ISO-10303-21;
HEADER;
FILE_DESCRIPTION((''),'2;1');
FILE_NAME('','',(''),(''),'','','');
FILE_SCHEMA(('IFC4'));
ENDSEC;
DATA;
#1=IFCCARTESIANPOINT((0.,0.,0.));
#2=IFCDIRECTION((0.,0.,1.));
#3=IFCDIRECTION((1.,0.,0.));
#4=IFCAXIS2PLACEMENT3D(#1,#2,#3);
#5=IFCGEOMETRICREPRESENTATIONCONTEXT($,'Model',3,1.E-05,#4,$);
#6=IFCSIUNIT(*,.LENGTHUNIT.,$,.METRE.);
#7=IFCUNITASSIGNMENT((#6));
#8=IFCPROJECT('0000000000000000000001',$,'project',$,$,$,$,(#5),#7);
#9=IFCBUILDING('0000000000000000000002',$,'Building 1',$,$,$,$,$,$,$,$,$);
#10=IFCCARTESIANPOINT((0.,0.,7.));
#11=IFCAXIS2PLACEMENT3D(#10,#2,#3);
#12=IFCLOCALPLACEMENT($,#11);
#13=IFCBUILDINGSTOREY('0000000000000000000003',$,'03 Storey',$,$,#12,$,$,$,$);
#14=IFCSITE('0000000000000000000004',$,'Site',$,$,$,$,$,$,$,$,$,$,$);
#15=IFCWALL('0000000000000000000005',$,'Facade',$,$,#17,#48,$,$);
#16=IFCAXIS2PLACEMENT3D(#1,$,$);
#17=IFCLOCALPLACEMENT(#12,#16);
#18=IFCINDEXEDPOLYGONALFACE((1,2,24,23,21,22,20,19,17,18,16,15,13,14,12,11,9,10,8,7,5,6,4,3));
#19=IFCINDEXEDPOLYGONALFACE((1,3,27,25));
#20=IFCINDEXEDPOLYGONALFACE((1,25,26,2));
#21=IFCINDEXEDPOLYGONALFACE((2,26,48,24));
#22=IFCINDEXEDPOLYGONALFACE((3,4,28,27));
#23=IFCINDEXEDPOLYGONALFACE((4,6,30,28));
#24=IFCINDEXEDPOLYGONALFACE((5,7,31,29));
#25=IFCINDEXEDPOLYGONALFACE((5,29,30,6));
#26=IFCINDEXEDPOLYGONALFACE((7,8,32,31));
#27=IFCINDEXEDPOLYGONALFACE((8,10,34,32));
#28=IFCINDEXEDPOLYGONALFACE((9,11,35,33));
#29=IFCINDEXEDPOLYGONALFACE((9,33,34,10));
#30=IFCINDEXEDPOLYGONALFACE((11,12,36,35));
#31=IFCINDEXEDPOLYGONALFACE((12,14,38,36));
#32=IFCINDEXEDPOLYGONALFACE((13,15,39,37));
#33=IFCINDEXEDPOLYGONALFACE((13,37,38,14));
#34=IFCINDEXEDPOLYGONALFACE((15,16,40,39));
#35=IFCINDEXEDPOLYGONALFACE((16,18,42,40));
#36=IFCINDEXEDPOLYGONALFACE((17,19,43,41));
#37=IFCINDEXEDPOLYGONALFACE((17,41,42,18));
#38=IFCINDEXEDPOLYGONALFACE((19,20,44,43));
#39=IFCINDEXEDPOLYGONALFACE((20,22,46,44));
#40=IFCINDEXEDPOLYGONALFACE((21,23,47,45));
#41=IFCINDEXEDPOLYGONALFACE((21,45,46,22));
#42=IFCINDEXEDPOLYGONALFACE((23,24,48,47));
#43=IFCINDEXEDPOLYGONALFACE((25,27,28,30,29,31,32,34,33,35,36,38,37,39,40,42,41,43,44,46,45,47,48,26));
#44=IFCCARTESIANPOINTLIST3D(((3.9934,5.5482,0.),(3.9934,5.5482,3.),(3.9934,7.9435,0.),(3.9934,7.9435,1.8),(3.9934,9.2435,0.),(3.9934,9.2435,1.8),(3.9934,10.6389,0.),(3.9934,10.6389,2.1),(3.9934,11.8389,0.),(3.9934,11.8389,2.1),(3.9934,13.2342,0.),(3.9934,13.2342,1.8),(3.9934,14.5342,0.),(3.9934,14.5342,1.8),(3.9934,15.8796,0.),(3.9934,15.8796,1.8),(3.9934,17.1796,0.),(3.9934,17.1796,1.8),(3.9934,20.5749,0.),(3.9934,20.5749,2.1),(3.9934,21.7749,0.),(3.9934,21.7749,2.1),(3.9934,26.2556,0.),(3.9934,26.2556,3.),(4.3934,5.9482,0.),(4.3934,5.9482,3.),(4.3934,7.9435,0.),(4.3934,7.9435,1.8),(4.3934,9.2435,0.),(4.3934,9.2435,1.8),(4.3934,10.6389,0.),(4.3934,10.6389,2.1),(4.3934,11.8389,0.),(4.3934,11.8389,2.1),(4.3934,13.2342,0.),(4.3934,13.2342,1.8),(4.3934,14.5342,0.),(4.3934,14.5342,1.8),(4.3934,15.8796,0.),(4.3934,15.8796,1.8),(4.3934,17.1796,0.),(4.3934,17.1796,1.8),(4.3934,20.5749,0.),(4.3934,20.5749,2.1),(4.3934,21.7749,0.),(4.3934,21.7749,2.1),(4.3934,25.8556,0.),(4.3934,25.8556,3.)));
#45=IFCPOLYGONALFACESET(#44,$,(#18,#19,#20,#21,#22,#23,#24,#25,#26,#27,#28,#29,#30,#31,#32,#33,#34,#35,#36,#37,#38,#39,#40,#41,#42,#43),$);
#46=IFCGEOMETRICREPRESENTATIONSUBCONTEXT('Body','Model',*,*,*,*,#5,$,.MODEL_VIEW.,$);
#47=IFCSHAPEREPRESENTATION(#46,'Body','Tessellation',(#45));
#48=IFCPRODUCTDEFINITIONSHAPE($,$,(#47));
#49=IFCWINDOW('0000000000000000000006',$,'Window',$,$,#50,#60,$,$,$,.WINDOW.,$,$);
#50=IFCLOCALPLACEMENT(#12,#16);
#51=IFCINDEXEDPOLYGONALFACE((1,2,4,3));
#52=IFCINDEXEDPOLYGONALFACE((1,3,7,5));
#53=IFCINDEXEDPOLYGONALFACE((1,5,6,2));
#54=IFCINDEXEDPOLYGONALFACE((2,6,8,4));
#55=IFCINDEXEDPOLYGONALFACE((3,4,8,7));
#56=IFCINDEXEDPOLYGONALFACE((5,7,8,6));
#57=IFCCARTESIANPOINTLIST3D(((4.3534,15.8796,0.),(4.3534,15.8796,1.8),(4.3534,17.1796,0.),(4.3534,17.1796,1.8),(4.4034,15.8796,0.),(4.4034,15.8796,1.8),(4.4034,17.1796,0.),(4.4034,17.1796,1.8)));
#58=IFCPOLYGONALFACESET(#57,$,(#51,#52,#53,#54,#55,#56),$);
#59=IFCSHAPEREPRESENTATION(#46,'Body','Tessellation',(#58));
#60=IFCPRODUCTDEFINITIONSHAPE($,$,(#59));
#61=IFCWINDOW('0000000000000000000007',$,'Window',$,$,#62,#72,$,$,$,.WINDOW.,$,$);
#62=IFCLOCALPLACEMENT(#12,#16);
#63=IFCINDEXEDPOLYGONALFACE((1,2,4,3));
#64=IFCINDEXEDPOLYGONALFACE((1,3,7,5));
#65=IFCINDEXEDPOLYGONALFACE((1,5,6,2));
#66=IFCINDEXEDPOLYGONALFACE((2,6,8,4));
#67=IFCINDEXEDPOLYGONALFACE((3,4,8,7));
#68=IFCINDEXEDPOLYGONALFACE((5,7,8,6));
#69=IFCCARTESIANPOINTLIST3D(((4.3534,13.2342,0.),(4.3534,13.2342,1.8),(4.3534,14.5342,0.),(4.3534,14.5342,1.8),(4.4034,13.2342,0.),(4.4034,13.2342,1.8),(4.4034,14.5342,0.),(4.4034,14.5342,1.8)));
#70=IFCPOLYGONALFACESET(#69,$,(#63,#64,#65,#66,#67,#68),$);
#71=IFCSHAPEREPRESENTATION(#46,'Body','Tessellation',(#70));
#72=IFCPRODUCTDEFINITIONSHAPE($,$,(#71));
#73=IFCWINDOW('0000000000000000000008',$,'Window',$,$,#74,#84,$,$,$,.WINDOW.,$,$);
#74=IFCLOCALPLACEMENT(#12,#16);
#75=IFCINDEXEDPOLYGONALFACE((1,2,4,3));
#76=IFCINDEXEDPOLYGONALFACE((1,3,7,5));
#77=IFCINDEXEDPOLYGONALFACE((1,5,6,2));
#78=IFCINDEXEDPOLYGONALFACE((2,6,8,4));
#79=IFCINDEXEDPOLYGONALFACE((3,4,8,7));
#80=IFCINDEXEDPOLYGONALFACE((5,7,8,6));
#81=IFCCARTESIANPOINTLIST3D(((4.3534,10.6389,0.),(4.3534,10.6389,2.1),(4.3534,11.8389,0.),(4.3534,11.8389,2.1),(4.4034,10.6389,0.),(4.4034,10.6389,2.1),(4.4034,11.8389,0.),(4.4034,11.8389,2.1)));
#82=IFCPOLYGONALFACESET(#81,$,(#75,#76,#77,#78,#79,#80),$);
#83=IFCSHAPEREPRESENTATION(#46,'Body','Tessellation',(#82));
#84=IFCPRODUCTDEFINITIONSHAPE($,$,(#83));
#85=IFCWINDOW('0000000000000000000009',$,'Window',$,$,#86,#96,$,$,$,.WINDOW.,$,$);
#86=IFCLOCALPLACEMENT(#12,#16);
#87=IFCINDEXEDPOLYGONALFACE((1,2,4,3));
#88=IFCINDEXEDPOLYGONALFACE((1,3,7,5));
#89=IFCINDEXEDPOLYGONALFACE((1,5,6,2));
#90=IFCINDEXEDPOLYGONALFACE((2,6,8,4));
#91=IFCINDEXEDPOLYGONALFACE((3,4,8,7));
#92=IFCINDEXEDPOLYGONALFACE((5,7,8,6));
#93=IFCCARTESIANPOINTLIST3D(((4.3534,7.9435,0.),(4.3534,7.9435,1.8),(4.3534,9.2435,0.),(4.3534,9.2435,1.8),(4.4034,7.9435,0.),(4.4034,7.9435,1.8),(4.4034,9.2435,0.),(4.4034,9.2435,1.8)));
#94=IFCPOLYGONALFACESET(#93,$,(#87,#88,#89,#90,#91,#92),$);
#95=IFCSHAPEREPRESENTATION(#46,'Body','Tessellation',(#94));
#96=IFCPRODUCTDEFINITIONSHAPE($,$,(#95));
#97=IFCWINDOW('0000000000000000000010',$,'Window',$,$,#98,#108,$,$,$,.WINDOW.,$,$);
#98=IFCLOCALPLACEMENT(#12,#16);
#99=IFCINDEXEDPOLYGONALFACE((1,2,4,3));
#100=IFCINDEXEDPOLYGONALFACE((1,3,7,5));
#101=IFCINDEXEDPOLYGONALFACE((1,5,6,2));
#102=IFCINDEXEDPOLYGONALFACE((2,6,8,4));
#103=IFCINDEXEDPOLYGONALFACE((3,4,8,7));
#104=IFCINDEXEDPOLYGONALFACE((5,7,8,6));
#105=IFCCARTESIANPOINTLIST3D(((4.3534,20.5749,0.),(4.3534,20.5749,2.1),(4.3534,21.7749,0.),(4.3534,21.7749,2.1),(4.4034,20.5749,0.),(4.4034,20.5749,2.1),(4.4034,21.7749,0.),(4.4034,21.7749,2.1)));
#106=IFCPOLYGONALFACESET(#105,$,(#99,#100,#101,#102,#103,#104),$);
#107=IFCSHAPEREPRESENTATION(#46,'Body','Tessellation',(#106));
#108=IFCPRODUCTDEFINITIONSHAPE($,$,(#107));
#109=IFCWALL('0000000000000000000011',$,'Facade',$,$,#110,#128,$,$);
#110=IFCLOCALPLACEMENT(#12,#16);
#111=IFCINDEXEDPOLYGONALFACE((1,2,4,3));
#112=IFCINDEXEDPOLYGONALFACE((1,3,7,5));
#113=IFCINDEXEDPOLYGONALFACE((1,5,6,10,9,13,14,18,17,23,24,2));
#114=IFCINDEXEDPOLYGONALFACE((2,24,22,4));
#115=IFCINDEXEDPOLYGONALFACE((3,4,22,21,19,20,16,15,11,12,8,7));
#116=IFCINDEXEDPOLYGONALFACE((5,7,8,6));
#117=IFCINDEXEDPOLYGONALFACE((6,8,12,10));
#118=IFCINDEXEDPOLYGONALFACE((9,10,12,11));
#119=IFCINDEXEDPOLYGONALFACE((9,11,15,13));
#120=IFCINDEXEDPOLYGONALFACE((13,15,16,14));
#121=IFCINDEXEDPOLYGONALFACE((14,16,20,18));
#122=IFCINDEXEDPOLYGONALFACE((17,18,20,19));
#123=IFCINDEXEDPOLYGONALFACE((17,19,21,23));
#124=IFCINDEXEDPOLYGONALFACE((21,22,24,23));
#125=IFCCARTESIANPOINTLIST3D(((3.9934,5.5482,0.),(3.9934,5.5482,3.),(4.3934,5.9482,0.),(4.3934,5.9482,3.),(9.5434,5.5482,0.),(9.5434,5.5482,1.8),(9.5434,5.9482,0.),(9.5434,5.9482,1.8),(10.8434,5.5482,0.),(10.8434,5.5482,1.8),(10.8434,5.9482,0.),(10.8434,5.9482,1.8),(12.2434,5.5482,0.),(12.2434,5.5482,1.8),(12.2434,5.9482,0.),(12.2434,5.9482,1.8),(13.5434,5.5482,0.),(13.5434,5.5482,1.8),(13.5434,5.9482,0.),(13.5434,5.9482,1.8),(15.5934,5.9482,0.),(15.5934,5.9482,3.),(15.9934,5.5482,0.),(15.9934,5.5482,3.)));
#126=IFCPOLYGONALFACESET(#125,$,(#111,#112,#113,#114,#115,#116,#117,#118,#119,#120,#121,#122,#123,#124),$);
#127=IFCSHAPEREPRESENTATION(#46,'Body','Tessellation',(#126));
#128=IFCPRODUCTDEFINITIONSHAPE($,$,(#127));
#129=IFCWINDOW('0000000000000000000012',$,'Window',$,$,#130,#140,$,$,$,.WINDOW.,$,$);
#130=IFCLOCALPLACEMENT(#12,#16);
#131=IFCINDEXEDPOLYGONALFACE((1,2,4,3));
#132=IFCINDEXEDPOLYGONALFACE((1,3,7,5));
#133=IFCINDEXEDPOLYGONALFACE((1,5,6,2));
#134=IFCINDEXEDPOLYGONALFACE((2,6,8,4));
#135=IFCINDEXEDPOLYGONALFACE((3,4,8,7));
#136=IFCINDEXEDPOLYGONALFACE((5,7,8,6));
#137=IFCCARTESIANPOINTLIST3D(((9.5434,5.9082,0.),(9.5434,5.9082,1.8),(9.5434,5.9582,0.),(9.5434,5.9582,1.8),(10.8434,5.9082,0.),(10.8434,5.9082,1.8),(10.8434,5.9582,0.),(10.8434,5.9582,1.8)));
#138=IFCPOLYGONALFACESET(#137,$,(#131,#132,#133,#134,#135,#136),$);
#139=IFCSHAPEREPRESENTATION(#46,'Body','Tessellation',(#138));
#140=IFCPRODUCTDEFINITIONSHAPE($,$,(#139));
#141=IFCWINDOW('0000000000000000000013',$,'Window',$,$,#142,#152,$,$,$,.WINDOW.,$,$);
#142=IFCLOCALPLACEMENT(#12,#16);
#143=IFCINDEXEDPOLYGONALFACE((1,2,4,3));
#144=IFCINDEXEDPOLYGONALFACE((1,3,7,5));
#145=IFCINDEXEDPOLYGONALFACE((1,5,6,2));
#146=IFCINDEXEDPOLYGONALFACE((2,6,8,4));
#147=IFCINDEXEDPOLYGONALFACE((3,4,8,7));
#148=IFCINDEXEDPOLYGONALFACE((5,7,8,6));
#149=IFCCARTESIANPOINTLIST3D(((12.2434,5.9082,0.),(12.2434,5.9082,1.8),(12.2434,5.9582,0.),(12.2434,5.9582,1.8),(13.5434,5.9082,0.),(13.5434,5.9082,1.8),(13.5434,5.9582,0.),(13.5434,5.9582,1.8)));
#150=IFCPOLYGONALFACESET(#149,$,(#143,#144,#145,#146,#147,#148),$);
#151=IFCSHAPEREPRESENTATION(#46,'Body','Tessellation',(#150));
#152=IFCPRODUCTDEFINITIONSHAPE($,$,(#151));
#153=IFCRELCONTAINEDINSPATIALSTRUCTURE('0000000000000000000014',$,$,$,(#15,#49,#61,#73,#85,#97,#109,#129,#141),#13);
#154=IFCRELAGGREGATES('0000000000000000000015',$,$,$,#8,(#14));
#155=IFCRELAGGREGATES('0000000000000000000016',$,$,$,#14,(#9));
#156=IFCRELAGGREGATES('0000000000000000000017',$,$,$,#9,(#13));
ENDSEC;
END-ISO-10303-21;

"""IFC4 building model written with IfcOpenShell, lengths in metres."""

from ifc_helpers import new_model, si_unit, frame, origin_with_axes, place, context, subcontext, project, spatial, line, indexed_curve, outline, extrude, element, fill, save


model = new_model("IFC4")

# Units and contexts
model_context = context("Model", 3, precision=1e-05, world=origin_with_axes())
body_context = subcontext(model_context, "Body", "Model", "MODEL_VIEW")
ifc_project = project(units=[si_unit("LENGTHUNIT", "METRE")], contexts=[model_context])

# Site, building, storey
site = spatial("IfcSite", under=ifc_project, Name="Site")
building = spatial("IfcBuilding", under=site, Name="Building 1")
storey_placement = place(None, frame((0.0, 0.0, 7.0), z_axis=(0.0, 0.0, 1.0), x_axis=(1.0, 0.0, 0.0)))
storey = spatial("IfcBuildingStorey", under=building, at=storey_placement, Name="03 Storey")

# Walls, openings, windows
wall_1_placement = place(storey_placement, origin_with_axes())
wall_1 = element("IfcWall", 1, at=wall_1_placement, inside=storey, Name="Facade", context=body_context, shape_type="SweptSolid", body=[
    extrude(outline(indexed_curve([(4.3934, 25.8556), (4.3934, 5.9482), (3.9934, 5.5482), (3.9934, 26.2556)], segments=[line(1, 2), line(2, 3), line(3, 4)])), origin_with_axes(), (0.0, 0.0, 1.0), 3.0),
])
opening_1_placement = place(wall_1_placement, origin_with_axes())
opening_1 = element("IfcOpeningElement", 2, at=opening_1_placement, cuts=wall_1, context=body_context, shape_type="SweptSolid", body=[
    extrude(outline(indexed_curve([(3.9534, 17.1796), (4.4534, 17.1796), (4.4534, 15.8796), (3.9534, 15.8796)], segments=[line(1, 2), line(2, 3), line(3, 4)])), origin_with_axes(), (0.0, 0.0, 1.0), 1.8),
])
opening_2_placement = place(wall_1_placement, origin_with_axes())
opening_2 = element("IfcOpeningElement", 3, at=opening_2_placement, cuts=wall_1, context=body_context, shape_type="SweptSolid", body=[
    extrude(outline(indexed_curve([(3.9534, 14.5342), (4.4534, 14.5342), (4.4534, 13.2342), (3.9534, 13.2342)], segments=[line(1, 2), line(2, 3), line(3, 4)])), origin_with_axes(), (0.0, 0.0, 1.0), 1.8),
])
opening_3_placement = place(wall_1_placement, origin_with_axes())
opening_3 = element("IfcOpeningElement", 4, at=opening_3_placement, cuts=wall_1, context=body_context, shape_type="SweptSolid", body=[
    extrude(outline(indexed_curve([(3.9534, 11.8389), (4.4534, 11.8389), (4.4534, 10.6389), (3.9534, 10.6389)], segments=[line(1, 2), line(2, 3), line(3, 4)])), origin_with_axes(), (0.0, 0.0, 1.0), 2.1),
])
opening_4_placement = place(wall_1_placement, origin_with_axes())
opening_4 = element("IfcOpeningElement", 5, at=opening_4_placement, cuts=wall_1, context=body_context, shape_type="SweptSolid", body=[
    extrude(outline(indexed_curve([(3.9534, 9.2435), (4.4534, 9.2435), (4.4534, 7.9435), (3.9534, 7.9435)], segments=[line(1, 2), line(2, 3), line(3, 4)])), origin_with_axes(), (0.0, 0.0, 1.0), 1.8),
])
opening_5_placement = place(wall_1_placement, origin_with_axes())
opening_5 = element("IfcOpeningElement", 6, at=opening_5_placement, cuts=wall_1, context=body_context, shape_type="SweptSolid", body=[
    extrude(outline(indexed_curve([(3.9534, 21.7749), (4.4534, 21.7749), (4.4534, 20.5749), (3.9534, 20.5749)], segments=[line(1, 2), line(2, 3), line(3, 4)])), origin_with_axes(), (0.0, 0.0, 1.0), 2.1),
])
window_1_placement = place(storey_placement, origin_with_axes())
window_1 = element("IfcWindow", 7, at=window_1_placement, inside=storey, Name="Window", PredefinedType="WINDOW", context=body_context, shape_type="SweptSolid", body=[
    extrude(outline(indexed_curve([(4.3534, 17.1796), (4.4034, 17.1796), (4.4034, 15.8796), (4.3534, 15.8796)], segments=[line(1, 2), line(2, 3), line(3, 4)])), origin_with_axes(), (0.0, 0.0, 1.0), 1.8),
])
fill(opening_1, window_1)
window_2_placement = place(storey_placement, origin_with_axes())
window_2 = element("IfcWindow", 8, at=window_2_placement, inside=storey, Name="Window", PredefinedType="WINDOW", context=body_context, shape_type="SweptSolid", body=[
    extrude(outline(indexed_curve([(4.3534, 14.5342), (4.4034, 14.5342), (4.4034, 13.2342), (4.3534, 13.2342)], segments=[line(1, 2), line(2, 3), line(3, 4)])), origin_with_axes(), (0.0, 0.0, 1.0), 1.8),
])
fill(opening_2, window_2)
window_3_placement = place(storey_placement, origin_with_axes())
window_3 = element("IfcWindow", 9, at=window_3_placement, inside=storey, Name="Window", PredefinedType="WINDOW", context=body_context, shape_type="SweptSolid", body=[
    extrude(outline(indexed_curve([(4.3534, 11.8389), (4.4034, 11.8389), (4.4034, 10.6389), (4.3534, 10.6389)], segments=[line(1, 2), line(2, 3), line(3, 4)])), origin_with_axes(), (0.0, 0.0, 1.0), 2.1),
])
fill(opening_3, window_3)
window_4_placement = place(storey_placement, origin_with_axes())
window_4 = element("IfcWindow", 10, at=window_4_placement, inside=storey, Name="Window", PredefinedType="WINDOW", context=body_context, shape_type="SweptSolid", body=[
    extrude(outline(indexed_curve([(4.3534, 9.2435), (4.4034, 9.2435), (4.4034, 7.9435), (4.3534, 7.9435)], segments=[line(1, 2), line(2, 3), line(3, 4)])), origin_with_axes(), (0.0, 0.0, 1.0), 1.8),
])
fill(opening_4, window_4)
window_5_placement = place(storey_placement, origin_with_axes())
window_5 = element("IfcWindow", 11, at=window_5_placement, inside=storey, Name="Window", PredefinedType="WINDOW", context=body_context, shape_type="SweptSolid", body=[
    extrude(outline(indexed_curve([(4.3534, 21.7749), (4.4034, 21.7749), (4.4034, 20.5749), (4.3534, 20.5749)], segments=[line(1, 2), line(2, 3), line(3, 4)])), origin_with_axes(), (0.0, 0.0, 1.0), 2.1),
])
fill(opening_5, window_5)
wall_2_placement = place(storey_placement, origin_with_axes())
wall_2 = element("IfcWall", 12, at=wall_2_placement, inside=storey, Name="Facade", context=body_context, shape_type="SweptSolid", body=[
    extrude(outline(indexed_curve([(4.3934, 5.9482), (15.5934, 5.9482), (15.9934, 5.5482), (3.9934, 5.5482)], segments=[line(1, 2), line(2, 3), line(3, 4)])), origin_with_axes(), (0.0, 0.0, 1.0), 3.0),
])
opening_6_placement = place(wall_2_placement, origin_with_axes())
opening_6 = element("IfcOpeningElement", 13, at=opening_6_placement, cuts=wall_2, context=body_context, shape_type="SweptSolid", body=[
    extrude(outline(indexed_curve([(9.5434, 5.5082), (9.5434, 6.0082), (10.8434, 6.0082), (10.8434, 5.5082)], segments=[line(1, 2), line(2, 3), line(3, 4)])), origin_with_axes(), (0.0, 0.0, 1.0), 1.8),
])
opening_7_placement = place(wall_2_placement, origin_with_axes())
opening_7 = element("IfcOpeningElement", 14, at=opening_7_placement, cuts=wall_2, context=body_context, shape_type="SweptSolid", body=[
    extrude(outline(indexed_curve([(12.2434, 5.5082), (12.2434, 6.0082), (13.5434, 6.0082), (13.5434, 5.5082)], segments=[line(1, 2), line(2, 3), line(3, 4)])), origin_with_axes(), (0.0, 0.0, 1.0), 1.8),
])
window_6_placement = place(storey_placement, origin_with_axes())
window_6 = element("IfcWindow", 15, at=window_6_placement, inside=storey, Name="Window", PredefinedType="WINDOW", context=body_context, shape_type="SweptSolid", body=[
    extrude(outline(indexed_curve([(9.5434, 5.9082), (9.5434, 5.9582), (10.8434, 5.9582), (10.8434, 5.9082)], segments=[line(1, 2), line(2, 3), line(3, 4)])), origin_with_axes(), (0.0, 0.0, 1.0), 1.8),
])
fill(opening_6, window_6)
window_7_placement = place(storey_placement, origin_with_axes())
window_7 = element("IfcWindow", 16, at=window_7_placement, inside=storey, Name="Window", PredefinedType="WINDOW", context=body_context, shape_type="SweptSolid", body=[
    extrude(outline(indexed_curve([(12.2434, 5.9082), (12.2434, 5.9582), (13.5434, 5.9582), (13.5434, 5.9082)], segments=[line(1, 2), line(2, 3), line(3, 4)])), origin_with_axes(), (0.0, 0.0, 1.0), 1.8),
])
fill(opening_7, window_7)

save(model, "model.ifc")
